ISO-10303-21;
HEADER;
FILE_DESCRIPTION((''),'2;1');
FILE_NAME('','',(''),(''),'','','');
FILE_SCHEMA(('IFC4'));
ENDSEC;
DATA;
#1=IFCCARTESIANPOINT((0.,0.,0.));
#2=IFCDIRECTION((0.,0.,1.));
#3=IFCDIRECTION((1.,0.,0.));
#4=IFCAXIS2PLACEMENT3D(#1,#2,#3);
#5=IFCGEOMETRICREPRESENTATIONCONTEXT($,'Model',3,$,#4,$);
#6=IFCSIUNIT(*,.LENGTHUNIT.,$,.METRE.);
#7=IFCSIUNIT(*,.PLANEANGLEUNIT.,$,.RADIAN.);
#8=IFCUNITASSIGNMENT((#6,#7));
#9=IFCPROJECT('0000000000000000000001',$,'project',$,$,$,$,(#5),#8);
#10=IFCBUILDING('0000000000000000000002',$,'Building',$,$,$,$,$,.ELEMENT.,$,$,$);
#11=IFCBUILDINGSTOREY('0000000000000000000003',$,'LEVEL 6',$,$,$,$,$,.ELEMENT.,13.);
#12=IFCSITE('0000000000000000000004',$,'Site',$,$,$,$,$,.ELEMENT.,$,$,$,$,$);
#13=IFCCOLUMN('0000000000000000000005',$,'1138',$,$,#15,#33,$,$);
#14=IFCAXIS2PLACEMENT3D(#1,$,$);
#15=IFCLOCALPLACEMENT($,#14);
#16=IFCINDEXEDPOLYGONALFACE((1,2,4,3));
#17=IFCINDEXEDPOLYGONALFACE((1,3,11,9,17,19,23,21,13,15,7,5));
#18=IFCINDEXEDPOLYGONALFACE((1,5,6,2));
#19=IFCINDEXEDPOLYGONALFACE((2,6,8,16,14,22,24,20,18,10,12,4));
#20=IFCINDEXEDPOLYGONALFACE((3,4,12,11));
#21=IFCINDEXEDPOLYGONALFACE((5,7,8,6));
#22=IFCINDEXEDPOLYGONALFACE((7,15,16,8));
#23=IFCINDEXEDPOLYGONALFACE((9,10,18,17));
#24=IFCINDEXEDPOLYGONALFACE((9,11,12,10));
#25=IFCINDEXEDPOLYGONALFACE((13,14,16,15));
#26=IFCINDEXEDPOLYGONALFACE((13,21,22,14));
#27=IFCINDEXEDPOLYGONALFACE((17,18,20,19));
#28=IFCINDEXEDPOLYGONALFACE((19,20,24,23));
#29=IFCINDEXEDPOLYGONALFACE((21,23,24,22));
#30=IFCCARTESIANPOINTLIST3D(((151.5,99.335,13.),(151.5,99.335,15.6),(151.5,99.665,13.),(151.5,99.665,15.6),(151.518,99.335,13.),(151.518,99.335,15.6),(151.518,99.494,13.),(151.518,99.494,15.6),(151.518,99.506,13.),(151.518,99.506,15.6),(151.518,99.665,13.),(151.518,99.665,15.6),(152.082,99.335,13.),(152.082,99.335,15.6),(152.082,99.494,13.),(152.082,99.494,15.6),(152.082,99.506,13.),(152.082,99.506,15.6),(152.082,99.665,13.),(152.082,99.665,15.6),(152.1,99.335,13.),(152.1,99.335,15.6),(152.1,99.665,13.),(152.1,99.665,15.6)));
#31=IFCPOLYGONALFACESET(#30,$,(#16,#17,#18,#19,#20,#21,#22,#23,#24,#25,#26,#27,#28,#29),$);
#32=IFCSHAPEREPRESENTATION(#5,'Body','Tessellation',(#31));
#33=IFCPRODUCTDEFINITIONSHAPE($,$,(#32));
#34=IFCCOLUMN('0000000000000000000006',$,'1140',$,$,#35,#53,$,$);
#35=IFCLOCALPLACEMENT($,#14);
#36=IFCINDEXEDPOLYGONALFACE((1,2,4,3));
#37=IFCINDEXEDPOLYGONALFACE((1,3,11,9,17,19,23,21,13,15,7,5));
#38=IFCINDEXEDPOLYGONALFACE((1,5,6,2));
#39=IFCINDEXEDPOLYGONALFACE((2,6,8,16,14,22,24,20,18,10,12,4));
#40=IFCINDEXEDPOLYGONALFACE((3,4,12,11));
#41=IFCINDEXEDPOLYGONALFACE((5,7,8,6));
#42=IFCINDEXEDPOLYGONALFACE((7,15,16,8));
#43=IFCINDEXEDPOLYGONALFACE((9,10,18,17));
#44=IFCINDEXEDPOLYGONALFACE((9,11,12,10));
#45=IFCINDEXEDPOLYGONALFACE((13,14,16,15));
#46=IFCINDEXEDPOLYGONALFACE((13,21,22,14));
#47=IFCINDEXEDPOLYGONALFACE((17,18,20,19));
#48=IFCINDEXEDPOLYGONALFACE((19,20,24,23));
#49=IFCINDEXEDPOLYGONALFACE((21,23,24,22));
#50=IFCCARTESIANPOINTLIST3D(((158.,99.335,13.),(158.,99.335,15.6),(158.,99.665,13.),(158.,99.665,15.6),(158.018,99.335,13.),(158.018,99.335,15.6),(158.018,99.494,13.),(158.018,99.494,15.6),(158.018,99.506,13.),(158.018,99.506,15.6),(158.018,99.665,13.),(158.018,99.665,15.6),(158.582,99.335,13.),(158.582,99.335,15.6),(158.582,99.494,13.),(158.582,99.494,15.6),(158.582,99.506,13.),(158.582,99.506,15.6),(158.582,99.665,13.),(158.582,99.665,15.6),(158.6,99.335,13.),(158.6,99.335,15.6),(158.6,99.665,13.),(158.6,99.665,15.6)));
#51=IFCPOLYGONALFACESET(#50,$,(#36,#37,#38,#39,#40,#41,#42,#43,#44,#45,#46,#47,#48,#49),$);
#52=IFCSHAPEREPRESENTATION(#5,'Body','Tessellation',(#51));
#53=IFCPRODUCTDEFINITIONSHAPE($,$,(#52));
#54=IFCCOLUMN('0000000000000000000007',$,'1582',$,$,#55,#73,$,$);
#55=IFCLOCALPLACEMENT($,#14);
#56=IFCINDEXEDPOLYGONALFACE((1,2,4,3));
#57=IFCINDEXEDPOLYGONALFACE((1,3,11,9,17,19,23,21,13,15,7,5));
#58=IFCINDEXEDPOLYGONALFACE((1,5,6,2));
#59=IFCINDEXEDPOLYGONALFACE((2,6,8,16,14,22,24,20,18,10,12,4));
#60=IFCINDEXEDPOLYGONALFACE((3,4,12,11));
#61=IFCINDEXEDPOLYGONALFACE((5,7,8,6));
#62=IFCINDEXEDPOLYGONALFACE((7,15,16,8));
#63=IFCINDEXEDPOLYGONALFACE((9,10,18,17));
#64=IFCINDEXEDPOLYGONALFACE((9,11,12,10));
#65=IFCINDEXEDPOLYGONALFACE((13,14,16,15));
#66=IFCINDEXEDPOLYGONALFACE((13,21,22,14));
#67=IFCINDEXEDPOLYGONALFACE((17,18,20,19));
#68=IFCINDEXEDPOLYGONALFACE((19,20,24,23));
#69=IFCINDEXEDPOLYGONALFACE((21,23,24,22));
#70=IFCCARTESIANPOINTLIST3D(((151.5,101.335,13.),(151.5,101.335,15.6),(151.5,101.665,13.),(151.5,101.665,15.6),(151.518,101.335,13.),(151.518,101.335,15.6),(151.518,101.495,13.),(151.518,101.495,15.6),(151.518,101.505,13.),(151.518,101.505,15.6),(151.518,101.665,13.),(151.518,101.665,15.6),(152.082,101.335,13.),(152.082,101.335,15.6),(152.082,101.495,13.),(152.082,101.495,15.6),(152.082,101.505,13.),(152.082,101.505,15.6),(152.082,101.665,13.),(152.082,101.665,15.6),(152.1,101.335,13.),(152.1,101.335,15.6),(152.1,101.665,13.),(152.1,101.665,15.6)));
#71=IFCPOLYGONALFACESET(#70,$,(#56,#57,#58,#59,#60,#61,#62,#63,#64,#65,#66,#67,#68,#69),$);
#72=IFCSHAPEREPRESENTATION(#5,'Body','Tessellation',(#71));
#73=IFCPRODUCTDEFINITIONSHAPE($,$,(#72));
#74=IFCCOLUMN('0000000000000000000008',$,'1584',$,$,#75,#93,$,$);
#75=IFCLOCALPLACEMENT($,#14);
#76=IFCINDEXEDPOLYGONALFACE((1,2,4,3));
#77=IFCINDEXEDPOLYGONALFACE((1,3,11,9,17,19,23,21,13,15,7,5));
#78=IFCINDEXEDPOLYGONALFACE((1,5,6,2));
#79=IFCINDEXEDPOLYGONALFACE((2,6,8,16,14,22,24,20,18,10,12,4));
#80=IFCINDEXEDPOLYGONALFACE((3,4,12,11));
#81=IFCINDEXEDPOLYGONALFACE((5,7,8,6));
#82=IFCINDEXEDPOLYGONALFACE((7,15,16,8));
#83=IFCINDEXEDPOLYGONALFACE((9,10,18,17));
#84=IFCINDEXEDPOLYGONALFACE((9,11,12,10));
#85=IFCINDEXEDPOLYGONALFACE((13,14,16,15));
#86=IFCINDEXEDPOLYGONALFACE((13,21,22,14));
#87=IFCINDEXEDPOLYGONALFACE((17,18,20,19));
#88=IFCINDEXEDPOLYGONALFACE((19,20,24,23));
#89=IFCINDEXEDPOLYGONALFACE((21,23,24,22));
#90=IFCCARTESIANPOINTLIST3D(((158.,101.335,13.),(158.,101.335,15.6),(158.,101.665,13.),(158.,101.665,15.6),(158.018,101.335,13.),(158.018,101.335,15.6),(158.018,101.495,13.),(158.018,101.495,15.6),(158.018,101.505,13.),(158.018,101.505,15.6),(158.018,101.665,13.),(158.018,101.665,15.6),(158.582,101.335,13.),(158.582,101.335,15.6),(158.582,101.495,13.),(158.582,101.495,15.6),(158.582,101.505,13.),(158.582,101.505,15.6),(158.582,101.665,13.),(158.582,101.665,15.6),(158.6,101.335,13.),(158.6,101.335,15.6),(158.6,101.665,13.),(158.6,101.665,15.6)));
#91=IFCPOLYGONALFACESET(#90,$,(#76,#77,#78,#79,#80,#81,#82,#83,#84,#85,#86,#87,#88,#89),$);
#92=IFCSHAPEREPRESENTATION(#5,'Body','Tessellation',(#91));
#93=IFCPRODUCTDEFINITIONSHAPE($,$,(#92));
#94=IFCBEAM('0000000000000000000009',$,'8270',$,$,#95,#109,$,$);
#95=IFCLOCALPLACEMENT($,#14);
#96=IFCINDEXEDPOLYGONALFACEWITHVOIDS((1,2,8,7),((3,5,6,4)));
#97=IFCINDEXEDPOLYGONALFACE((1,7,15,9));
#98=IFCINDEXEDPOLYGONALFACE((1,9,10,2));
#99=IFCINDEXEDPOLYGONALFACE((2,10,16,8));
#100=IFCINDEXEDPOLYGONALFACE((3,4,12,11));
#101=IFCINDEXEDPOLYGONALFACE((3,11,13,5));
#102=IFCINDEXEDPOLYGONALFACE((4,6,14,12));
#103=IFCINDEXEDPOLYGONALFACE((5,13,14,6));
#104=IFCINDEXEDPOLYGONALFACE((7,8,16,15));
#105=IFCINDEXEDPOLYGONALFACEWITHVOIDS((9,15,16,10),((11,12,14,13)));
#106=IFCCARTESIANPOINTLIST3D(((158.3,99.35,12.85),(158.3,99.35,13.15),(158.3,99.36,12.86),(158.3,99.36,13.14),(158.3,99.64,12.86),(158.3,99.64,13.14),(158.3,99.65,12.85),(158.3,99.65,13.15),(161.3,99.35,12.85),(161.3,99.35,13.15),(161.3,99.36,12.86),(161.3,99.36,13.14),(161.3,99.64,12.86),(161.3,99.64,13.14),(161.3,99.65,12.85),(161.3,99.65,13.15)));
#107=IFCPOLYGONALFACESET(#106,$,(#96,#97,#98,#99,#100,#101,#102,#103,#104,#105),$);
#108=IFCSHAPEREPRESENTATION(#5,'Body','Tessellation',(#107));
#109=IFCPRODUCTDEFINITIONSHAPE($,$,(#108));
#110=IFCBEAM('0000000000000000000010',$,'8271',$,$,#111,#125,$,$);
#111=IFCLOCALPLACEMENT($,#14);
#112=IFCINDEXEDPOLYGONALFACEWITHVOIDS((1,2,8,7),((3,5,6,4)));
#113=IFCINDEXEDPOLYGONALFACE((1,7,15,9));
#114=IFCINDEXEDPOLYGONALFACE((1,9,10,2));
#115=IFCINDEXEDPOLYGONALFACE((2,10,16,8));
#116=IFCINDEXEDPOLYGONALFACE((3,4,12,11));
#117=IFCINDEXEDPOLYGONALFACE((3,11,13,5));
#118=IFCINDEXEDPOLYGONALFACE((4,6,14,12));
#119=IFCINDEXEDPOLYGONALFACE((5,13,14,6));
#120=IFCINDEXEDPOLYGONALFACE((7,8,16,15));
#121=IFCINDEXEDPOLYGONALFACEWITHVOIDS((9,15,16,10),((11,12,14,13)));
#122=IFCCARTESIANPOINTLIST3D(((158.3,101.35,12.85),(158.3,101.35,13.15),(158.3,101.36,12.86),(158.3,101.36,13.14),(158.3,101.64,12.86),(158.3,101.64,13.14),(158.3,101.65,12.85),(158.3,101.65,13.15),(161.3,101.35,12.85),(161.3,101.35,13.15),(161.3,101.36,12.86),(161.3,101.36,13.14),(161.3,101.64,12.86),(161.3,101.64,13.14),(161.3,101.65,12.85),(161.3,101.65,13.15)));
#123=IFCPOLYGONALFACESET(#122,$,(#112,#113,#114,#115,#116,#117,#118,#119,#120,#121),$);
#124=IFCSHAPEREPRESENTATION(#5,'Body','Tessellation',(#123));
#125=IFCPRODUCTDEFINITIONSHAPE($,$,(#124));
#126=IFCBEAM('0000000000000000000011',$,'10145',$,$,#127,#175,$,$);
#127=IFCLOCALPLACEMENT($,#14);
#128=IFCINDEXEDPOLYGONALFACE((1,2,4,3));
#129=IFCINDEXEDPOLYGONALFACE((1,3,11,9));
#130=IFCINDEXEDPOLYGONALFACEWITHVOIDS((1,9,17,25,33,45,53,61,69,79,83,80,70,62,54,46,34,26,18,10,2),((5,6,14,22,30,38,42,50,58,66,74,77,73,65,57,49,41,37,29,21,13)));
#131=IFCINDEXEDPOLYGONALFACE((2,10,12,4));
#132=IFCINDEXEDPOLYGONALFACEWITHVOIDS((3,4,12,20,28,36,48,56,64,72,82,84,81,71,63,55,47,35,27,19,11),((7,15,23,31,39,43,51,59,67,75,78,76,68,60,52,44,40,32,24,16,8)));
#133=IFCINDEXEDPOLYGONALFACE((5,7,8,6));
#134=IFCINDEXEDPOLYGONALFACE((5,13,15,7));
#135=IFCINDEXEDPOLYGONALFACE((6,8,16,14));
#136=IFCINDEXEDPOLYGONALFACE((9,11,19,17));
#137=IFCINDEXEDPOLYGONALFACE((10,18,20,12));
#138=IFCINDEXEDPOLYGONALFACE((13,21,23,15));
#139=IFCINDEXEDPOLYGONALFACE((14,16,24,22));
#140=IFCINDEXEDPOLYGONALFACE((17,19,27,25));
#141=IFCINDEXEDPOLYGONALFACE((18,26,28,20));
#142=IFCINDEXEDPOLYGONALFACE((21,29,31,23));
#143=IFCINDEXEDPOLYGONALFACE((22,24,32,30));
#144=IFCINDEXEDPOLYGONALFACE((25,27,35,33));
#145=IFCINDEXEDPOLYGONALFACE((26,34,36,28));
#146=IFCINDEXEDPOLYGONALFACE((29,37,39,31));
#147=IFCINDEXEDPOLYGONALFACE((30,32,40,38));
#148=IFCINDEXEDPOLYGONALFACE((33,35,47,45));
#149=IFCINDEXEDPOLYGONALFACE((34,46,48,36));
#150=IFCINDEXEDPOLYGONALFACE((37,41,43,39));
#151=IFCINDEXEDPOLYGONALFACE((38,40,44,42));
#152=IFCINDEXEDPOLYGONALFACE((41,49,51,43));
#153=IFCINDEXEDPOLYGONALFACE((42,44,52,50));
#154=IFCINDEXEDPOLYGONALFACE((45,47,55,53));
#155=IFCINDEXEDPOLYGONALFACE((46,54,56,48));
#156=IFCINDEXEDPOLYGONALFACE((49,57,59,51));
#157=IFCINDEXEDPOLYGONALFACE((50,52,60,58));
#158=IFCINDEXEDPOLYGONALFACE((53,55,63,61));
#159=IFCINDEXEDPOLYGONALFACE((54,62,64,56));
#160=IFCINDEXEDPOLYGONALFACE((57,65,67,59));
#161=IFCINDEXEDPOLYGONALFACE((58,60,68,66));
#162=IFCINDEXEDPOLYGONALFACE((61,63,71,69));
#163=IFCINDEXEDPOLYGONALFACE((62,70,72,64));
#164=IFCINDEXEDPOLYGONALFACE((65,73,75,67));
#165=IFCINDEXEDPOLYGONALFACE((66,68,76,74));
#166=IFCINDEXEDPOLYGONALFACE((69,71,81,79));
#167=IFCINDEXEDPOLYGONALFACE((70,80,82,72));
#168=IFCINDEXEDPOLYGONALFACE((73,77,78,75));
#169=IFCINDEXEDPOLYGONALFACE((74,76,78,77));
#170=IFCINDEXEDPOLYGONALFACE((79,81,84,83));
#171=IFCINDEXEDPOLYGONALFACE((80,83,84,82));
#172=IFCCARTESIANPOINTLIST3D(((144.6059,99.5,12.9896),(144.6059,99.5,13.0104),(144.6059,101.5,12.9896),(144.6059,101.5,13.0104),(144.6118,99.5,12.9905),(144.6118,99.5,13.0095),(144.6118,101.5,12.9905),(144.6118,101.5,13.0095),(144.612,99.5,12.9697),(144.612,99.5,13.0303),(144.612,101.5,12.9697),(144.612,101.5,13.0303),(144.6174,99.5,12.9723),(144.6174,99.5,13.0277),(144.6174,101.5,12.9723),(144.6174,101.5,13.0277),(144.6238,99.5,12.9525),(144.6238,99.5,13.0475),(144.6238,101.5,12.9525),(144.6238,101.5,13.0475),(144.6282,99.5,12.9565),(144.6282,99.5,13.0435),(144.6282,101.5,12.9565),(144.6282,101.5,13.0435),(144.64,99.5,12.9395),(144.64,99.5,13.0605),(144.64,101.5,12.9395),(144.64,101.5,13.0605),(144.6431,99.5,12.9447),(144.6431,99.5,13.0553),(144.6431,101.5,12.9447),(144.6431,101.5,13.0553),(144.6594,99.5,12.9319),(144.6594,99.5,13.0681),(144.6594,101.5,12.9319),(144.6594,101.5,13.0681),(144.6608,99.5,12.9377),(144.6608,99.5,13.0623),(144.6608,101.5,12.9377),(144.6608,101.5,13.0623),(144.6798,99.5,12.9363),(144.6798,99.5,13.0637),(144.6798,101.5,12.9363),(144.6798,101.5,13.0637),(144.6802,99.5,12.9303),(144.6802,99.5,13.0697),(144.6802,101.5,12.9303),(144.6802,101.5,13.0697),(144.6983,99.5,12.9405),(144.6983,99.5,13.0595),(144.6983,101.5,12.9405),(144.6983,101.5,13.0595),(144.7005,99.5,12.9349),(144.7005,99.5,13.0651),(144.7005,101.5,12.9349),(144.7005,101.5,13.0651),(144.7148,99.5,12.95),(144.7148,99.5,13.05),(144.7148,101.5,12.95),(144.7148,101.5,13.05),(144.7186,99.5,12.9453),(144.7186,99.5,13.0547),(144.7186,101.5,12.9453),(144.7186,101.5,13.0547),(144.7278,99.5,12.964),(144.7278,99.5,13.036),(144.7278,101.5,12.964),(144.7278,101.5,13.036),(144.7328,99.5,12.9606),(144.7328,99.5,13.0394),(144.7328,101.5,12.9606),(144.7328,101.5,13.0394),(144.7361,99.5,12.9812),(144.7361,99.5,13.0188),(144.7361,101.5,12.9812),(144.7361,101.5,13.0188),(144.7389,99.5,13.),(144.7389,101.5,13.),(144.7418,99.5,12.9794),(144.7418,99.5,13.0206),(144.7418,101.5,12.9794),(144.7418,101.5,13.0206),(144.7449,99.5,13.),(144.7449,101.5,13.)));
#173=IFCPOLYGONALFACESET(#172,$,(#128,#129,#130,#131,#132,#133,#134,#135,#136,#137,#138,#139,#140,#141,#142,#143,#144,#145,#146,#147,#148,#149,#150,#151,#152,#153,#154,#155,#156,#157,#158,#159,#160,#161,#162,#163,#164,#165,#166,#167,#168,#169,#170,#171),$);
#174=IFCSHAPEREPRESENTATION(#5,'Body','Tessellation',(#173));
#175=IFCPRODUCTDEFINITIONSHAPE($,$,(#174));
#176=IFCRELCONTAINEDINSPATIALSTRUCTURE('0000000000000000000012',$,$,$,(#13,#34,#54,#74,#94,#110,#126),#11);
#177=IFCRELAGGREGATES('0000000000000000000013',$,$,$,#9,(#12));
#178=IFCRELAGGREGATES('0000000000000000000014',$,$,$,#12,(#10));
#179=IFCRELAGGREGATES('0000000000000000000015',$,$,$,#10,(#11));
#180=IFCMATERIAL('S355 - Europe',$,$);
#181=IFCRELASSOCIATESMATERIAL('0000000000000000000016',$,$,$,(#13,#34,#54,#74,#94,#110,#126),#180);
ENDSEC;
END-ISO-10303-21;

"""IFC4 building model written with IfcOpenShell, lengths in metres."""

from ifc_helpers import new_model, si_unit, frame, origin_with_axes, origin_2d_with_axis, place, context, project, spatial, hollow_rectangle, hollow_circle, i_section, extrude, material, material_profile, profile_set, profile_usage, element, save


model = new_model("IFC4")

# Units and contexts
model_context = context("Model", 3, world=origin_with_axes())
ifc_project = project(units=[si_unit("LENGTHUNIT", "METRE"), si_unit("PLANEANGLEUNIT", "RADIAN")], contexts=[model_context])

# Site, building, storey
site = spatial("IfcSite", under=ifc_project, Name="Site", CompositionType="ELEMENT")
building = spatial("IfcBuilding", under=site, Name="Building", CompositionType="ELEMENT")
storey = spatial("IfcBuildingStorey", under=building, Name="LEVEL 6", CompositionType="ELEMENT", Elevation=13.0)

# Columns
ifc_material = material(Name="S355 - Europe")
ifc_material_profile_1 = material_profile(ifc_material, i_section(OverallWidth=0.33, OverallDepth=0.6, WebThickness=0.012, FlangeThickness=0.018, at=origin_2d_with_axis()))
ifc_profile_set_1 = profile_set([ifc_material_profile_1])
ifc_profile_usage_1 = profile_usage(ifc_profile_set_1, cardinal=10)
column_1_placement = place(None, frame((151.8, 99.5, 13.0), z_axis=(0.0, 0.0, 1.0), x_axis=(0.0, -1.0, 0.0)))
element("IfcColumn", 1, at=column_1_placement, inside=storey, material=ifc_profile_usage_1, Name="1138", context=model_context, shape_type="SweptSolid", body=[
    extrude(i_section(OverallWidth=0.33, OverallDepth=0.6, WebThickness=0.012, FlangeThickness=0.018, at=origin_2d_with_axis()), origin_with_axes(), (0.0, 0.0, 1.0), 2.6),
])
ifc_material_profile_2 = material_profile(ifc_material, i_section(OverallWidth=0.33, OverallDepth=0.6, WebThickness=0.012, FlangeThickness=0.018, at=origin_2d_with_axis()))
ifc_profile_set_2 = profile_set([ifc_material_profile_2])
ifc_profile_usage_2 = profile_usage(ifc_profile_set_2, cardinal=10)
column_2_placement = place(None, frame((158.3, 99.5, 13.0), z_axis=(0.0, 0.0, 1.0), x_axis=(0.0, -1.0, 0.0)))
element("IfcColumn", 2, at=column_2_placement, inside=storey, material=ifc_profile_usage_2, Name="1140", context=model_context, shape_type="SweptSolid", body=[
    extrude(i_section(OverallWidth=0.33, OverallDepth=0.6, WebThickness=0.012, FlangeThickness=0.018, at=origin_2d_with_axis()), origin_with_axes(), (0.0, 0.0, 1.0), 2.6),
])
ifc_material_profile_3 = material_profile(ifc_material, i_section(OverallWidth=0.33, OverallDepth=0.6, WebThickness=0.01, FlangeThickness=0.018, at=origin_2d_with_axis()))
ifc_profile_set_3 = profile_set([ifc_material_profile_3])
ifc_profile_usage_3 = profile_usage(ifc_profile_set_3, cardinal=10)
column_3_placement = place(None, frame((151.8, 101.5, 13.0), z_axis=(0.0, 0.0, 1.0), x_axis=(0.0, -1.0, 0.0)))
element("IfcColumn", 3, at=column_3_placement, inside=storey, material=ifc_profile_usage_3, Name="1582", context=model_context, shape_type="SweptSolid", body=[
    extrude(i_section(OverallWidth=0.33, OverallDepth=0.6, WebThickness=0.01, FlangeThickness=0.018, at=origin_2d_with_axis()), origin_with_axes(), (0.0, 0.0, 1.0), 2.6),
])
ifc_material_profile_4 = material_profile(ifc_material, i_section(OverallWidth=0.33, OverallDepth=0.6, WebThickness=0.01, FlangeThickness=0.018, at=origin_2d_with_axis()))
ifc_profile_set_4 = profile_set([ifc_material_profile_4])
ifc_profile_usage_4 = profile_usage(ifc_profile_set_4, cardinal=10)
column_4_placement = place(None, frame((158.3, 101.5, 13.0), z_axis=(0.0, 0.0, 1.0), x_axis=(0.0, -1.0, 0.0)))
element("IfcColumn", 4, at=column_4_placement, inside=storey, material=ifc_profile_usage_4, Name="1584", context=model_context, shape_type="SweptSolid", body=[
    extrude(i_section(OverallWidth=0.33, OverallDepth=0.6, WebThickness=0.01, FlangeThickness=0.018, at=origin_2d_with_axis()), origin_with_axes(), (0.0, 0.0, 1.0), 2.6),
])

# Beams
ifc_material_profile_5 = material_profile(ifc_material, hollow_rectangle(XDim=0.3, YDim=0.3, WallThickness=0.01, at=origin_2d_with_axis()))
ifc_profile_set_5 = profile_set([ifc_material_profile_5])
ifc_profile_usage_5 = profile_usage(ifc_profile_set_5, cardinal=10)
beam_1_placement = place(None, frame((158.3, 99.5, 13.0), z_axis=(1.0, 0.0, 0.0), x_axis=(0.0, 1.0, 0.0)))
element("IfcBeam", 5, at=beam_1_placement, inside=storey, material=ifc_profile_usage_5, Name="8270", context=model_context, shape_type="SweptSolid", body=[
    extrude(hollow_rectangle(XDim=0.3, YDim=0.3, WallThickness=0.01, at=origin_2d_with_axis()), origin_with_axes(), (0.0, 0.0, 1.0), 3.0),
])
ifc_material_profile_6 = material_profile(ifc_material, hollow_rectangle(XDim=0.3, YDim=0.3, WallThickness=0.01, at=origin_2d_with_axis()))
ifc_profile_set_6 = profile_set([ifc_material_profile_6])
ifc_profile_usage_6 = profile_usage(ifc_profile_set_6, cardinal=10)
beam_2_placement = place(None, frame((158.3, 101.5, 13.0), z_axis=(1.0, 0.0, 0.0), x_axis=(0.0, 1.0, 0.0)))
element("IfcBeam", 6, at=beam_2_placement, inside=storey, material=ifc_profile_usage_6, Name="8271", context=model_context, shape_type="SweptSolid", body=[
    extrude(hollow_rectangle(XDim=0.3, YDim=0.3, WallThickness=0.01, at=origin_2d_with_axis()), origin_with_axes(), (0.0, 0.0, 1.0), 3.0),
])
ifc_material_profile_7 = material_profile(ifc_material, hollow_circle(Radius=0.0699, WallThickness=0.006, at=origin_2d_with_axis()))
ifc_profile_set_7 = profile_set([ifc_material_profile_7])
ifc_profile_usage_7 = profile_usage(ifc_profile_set_7, cardinal=10)
beam_3_placement = place(None, frame((144.675, 101.5, 13.0), z_axis=(0.0, -1.0, 0.0), x_axis=(1.0, 0.0, 0.0)))
element("IfcBeam", 7, at=beam_3_placement, inside=storey, material=ifc_profile_usage_7, Name="10145", context=model_context, shape_type="SweptSolid", body=[
    extrude(hollow_circle(Radius=0.0699, WallThickness=0.006, at=origin_2d_with_axis()), origin_with_axes(), (0.0, 0.0, 1.0), 2.0),
])

save(model, "model.ifc")
